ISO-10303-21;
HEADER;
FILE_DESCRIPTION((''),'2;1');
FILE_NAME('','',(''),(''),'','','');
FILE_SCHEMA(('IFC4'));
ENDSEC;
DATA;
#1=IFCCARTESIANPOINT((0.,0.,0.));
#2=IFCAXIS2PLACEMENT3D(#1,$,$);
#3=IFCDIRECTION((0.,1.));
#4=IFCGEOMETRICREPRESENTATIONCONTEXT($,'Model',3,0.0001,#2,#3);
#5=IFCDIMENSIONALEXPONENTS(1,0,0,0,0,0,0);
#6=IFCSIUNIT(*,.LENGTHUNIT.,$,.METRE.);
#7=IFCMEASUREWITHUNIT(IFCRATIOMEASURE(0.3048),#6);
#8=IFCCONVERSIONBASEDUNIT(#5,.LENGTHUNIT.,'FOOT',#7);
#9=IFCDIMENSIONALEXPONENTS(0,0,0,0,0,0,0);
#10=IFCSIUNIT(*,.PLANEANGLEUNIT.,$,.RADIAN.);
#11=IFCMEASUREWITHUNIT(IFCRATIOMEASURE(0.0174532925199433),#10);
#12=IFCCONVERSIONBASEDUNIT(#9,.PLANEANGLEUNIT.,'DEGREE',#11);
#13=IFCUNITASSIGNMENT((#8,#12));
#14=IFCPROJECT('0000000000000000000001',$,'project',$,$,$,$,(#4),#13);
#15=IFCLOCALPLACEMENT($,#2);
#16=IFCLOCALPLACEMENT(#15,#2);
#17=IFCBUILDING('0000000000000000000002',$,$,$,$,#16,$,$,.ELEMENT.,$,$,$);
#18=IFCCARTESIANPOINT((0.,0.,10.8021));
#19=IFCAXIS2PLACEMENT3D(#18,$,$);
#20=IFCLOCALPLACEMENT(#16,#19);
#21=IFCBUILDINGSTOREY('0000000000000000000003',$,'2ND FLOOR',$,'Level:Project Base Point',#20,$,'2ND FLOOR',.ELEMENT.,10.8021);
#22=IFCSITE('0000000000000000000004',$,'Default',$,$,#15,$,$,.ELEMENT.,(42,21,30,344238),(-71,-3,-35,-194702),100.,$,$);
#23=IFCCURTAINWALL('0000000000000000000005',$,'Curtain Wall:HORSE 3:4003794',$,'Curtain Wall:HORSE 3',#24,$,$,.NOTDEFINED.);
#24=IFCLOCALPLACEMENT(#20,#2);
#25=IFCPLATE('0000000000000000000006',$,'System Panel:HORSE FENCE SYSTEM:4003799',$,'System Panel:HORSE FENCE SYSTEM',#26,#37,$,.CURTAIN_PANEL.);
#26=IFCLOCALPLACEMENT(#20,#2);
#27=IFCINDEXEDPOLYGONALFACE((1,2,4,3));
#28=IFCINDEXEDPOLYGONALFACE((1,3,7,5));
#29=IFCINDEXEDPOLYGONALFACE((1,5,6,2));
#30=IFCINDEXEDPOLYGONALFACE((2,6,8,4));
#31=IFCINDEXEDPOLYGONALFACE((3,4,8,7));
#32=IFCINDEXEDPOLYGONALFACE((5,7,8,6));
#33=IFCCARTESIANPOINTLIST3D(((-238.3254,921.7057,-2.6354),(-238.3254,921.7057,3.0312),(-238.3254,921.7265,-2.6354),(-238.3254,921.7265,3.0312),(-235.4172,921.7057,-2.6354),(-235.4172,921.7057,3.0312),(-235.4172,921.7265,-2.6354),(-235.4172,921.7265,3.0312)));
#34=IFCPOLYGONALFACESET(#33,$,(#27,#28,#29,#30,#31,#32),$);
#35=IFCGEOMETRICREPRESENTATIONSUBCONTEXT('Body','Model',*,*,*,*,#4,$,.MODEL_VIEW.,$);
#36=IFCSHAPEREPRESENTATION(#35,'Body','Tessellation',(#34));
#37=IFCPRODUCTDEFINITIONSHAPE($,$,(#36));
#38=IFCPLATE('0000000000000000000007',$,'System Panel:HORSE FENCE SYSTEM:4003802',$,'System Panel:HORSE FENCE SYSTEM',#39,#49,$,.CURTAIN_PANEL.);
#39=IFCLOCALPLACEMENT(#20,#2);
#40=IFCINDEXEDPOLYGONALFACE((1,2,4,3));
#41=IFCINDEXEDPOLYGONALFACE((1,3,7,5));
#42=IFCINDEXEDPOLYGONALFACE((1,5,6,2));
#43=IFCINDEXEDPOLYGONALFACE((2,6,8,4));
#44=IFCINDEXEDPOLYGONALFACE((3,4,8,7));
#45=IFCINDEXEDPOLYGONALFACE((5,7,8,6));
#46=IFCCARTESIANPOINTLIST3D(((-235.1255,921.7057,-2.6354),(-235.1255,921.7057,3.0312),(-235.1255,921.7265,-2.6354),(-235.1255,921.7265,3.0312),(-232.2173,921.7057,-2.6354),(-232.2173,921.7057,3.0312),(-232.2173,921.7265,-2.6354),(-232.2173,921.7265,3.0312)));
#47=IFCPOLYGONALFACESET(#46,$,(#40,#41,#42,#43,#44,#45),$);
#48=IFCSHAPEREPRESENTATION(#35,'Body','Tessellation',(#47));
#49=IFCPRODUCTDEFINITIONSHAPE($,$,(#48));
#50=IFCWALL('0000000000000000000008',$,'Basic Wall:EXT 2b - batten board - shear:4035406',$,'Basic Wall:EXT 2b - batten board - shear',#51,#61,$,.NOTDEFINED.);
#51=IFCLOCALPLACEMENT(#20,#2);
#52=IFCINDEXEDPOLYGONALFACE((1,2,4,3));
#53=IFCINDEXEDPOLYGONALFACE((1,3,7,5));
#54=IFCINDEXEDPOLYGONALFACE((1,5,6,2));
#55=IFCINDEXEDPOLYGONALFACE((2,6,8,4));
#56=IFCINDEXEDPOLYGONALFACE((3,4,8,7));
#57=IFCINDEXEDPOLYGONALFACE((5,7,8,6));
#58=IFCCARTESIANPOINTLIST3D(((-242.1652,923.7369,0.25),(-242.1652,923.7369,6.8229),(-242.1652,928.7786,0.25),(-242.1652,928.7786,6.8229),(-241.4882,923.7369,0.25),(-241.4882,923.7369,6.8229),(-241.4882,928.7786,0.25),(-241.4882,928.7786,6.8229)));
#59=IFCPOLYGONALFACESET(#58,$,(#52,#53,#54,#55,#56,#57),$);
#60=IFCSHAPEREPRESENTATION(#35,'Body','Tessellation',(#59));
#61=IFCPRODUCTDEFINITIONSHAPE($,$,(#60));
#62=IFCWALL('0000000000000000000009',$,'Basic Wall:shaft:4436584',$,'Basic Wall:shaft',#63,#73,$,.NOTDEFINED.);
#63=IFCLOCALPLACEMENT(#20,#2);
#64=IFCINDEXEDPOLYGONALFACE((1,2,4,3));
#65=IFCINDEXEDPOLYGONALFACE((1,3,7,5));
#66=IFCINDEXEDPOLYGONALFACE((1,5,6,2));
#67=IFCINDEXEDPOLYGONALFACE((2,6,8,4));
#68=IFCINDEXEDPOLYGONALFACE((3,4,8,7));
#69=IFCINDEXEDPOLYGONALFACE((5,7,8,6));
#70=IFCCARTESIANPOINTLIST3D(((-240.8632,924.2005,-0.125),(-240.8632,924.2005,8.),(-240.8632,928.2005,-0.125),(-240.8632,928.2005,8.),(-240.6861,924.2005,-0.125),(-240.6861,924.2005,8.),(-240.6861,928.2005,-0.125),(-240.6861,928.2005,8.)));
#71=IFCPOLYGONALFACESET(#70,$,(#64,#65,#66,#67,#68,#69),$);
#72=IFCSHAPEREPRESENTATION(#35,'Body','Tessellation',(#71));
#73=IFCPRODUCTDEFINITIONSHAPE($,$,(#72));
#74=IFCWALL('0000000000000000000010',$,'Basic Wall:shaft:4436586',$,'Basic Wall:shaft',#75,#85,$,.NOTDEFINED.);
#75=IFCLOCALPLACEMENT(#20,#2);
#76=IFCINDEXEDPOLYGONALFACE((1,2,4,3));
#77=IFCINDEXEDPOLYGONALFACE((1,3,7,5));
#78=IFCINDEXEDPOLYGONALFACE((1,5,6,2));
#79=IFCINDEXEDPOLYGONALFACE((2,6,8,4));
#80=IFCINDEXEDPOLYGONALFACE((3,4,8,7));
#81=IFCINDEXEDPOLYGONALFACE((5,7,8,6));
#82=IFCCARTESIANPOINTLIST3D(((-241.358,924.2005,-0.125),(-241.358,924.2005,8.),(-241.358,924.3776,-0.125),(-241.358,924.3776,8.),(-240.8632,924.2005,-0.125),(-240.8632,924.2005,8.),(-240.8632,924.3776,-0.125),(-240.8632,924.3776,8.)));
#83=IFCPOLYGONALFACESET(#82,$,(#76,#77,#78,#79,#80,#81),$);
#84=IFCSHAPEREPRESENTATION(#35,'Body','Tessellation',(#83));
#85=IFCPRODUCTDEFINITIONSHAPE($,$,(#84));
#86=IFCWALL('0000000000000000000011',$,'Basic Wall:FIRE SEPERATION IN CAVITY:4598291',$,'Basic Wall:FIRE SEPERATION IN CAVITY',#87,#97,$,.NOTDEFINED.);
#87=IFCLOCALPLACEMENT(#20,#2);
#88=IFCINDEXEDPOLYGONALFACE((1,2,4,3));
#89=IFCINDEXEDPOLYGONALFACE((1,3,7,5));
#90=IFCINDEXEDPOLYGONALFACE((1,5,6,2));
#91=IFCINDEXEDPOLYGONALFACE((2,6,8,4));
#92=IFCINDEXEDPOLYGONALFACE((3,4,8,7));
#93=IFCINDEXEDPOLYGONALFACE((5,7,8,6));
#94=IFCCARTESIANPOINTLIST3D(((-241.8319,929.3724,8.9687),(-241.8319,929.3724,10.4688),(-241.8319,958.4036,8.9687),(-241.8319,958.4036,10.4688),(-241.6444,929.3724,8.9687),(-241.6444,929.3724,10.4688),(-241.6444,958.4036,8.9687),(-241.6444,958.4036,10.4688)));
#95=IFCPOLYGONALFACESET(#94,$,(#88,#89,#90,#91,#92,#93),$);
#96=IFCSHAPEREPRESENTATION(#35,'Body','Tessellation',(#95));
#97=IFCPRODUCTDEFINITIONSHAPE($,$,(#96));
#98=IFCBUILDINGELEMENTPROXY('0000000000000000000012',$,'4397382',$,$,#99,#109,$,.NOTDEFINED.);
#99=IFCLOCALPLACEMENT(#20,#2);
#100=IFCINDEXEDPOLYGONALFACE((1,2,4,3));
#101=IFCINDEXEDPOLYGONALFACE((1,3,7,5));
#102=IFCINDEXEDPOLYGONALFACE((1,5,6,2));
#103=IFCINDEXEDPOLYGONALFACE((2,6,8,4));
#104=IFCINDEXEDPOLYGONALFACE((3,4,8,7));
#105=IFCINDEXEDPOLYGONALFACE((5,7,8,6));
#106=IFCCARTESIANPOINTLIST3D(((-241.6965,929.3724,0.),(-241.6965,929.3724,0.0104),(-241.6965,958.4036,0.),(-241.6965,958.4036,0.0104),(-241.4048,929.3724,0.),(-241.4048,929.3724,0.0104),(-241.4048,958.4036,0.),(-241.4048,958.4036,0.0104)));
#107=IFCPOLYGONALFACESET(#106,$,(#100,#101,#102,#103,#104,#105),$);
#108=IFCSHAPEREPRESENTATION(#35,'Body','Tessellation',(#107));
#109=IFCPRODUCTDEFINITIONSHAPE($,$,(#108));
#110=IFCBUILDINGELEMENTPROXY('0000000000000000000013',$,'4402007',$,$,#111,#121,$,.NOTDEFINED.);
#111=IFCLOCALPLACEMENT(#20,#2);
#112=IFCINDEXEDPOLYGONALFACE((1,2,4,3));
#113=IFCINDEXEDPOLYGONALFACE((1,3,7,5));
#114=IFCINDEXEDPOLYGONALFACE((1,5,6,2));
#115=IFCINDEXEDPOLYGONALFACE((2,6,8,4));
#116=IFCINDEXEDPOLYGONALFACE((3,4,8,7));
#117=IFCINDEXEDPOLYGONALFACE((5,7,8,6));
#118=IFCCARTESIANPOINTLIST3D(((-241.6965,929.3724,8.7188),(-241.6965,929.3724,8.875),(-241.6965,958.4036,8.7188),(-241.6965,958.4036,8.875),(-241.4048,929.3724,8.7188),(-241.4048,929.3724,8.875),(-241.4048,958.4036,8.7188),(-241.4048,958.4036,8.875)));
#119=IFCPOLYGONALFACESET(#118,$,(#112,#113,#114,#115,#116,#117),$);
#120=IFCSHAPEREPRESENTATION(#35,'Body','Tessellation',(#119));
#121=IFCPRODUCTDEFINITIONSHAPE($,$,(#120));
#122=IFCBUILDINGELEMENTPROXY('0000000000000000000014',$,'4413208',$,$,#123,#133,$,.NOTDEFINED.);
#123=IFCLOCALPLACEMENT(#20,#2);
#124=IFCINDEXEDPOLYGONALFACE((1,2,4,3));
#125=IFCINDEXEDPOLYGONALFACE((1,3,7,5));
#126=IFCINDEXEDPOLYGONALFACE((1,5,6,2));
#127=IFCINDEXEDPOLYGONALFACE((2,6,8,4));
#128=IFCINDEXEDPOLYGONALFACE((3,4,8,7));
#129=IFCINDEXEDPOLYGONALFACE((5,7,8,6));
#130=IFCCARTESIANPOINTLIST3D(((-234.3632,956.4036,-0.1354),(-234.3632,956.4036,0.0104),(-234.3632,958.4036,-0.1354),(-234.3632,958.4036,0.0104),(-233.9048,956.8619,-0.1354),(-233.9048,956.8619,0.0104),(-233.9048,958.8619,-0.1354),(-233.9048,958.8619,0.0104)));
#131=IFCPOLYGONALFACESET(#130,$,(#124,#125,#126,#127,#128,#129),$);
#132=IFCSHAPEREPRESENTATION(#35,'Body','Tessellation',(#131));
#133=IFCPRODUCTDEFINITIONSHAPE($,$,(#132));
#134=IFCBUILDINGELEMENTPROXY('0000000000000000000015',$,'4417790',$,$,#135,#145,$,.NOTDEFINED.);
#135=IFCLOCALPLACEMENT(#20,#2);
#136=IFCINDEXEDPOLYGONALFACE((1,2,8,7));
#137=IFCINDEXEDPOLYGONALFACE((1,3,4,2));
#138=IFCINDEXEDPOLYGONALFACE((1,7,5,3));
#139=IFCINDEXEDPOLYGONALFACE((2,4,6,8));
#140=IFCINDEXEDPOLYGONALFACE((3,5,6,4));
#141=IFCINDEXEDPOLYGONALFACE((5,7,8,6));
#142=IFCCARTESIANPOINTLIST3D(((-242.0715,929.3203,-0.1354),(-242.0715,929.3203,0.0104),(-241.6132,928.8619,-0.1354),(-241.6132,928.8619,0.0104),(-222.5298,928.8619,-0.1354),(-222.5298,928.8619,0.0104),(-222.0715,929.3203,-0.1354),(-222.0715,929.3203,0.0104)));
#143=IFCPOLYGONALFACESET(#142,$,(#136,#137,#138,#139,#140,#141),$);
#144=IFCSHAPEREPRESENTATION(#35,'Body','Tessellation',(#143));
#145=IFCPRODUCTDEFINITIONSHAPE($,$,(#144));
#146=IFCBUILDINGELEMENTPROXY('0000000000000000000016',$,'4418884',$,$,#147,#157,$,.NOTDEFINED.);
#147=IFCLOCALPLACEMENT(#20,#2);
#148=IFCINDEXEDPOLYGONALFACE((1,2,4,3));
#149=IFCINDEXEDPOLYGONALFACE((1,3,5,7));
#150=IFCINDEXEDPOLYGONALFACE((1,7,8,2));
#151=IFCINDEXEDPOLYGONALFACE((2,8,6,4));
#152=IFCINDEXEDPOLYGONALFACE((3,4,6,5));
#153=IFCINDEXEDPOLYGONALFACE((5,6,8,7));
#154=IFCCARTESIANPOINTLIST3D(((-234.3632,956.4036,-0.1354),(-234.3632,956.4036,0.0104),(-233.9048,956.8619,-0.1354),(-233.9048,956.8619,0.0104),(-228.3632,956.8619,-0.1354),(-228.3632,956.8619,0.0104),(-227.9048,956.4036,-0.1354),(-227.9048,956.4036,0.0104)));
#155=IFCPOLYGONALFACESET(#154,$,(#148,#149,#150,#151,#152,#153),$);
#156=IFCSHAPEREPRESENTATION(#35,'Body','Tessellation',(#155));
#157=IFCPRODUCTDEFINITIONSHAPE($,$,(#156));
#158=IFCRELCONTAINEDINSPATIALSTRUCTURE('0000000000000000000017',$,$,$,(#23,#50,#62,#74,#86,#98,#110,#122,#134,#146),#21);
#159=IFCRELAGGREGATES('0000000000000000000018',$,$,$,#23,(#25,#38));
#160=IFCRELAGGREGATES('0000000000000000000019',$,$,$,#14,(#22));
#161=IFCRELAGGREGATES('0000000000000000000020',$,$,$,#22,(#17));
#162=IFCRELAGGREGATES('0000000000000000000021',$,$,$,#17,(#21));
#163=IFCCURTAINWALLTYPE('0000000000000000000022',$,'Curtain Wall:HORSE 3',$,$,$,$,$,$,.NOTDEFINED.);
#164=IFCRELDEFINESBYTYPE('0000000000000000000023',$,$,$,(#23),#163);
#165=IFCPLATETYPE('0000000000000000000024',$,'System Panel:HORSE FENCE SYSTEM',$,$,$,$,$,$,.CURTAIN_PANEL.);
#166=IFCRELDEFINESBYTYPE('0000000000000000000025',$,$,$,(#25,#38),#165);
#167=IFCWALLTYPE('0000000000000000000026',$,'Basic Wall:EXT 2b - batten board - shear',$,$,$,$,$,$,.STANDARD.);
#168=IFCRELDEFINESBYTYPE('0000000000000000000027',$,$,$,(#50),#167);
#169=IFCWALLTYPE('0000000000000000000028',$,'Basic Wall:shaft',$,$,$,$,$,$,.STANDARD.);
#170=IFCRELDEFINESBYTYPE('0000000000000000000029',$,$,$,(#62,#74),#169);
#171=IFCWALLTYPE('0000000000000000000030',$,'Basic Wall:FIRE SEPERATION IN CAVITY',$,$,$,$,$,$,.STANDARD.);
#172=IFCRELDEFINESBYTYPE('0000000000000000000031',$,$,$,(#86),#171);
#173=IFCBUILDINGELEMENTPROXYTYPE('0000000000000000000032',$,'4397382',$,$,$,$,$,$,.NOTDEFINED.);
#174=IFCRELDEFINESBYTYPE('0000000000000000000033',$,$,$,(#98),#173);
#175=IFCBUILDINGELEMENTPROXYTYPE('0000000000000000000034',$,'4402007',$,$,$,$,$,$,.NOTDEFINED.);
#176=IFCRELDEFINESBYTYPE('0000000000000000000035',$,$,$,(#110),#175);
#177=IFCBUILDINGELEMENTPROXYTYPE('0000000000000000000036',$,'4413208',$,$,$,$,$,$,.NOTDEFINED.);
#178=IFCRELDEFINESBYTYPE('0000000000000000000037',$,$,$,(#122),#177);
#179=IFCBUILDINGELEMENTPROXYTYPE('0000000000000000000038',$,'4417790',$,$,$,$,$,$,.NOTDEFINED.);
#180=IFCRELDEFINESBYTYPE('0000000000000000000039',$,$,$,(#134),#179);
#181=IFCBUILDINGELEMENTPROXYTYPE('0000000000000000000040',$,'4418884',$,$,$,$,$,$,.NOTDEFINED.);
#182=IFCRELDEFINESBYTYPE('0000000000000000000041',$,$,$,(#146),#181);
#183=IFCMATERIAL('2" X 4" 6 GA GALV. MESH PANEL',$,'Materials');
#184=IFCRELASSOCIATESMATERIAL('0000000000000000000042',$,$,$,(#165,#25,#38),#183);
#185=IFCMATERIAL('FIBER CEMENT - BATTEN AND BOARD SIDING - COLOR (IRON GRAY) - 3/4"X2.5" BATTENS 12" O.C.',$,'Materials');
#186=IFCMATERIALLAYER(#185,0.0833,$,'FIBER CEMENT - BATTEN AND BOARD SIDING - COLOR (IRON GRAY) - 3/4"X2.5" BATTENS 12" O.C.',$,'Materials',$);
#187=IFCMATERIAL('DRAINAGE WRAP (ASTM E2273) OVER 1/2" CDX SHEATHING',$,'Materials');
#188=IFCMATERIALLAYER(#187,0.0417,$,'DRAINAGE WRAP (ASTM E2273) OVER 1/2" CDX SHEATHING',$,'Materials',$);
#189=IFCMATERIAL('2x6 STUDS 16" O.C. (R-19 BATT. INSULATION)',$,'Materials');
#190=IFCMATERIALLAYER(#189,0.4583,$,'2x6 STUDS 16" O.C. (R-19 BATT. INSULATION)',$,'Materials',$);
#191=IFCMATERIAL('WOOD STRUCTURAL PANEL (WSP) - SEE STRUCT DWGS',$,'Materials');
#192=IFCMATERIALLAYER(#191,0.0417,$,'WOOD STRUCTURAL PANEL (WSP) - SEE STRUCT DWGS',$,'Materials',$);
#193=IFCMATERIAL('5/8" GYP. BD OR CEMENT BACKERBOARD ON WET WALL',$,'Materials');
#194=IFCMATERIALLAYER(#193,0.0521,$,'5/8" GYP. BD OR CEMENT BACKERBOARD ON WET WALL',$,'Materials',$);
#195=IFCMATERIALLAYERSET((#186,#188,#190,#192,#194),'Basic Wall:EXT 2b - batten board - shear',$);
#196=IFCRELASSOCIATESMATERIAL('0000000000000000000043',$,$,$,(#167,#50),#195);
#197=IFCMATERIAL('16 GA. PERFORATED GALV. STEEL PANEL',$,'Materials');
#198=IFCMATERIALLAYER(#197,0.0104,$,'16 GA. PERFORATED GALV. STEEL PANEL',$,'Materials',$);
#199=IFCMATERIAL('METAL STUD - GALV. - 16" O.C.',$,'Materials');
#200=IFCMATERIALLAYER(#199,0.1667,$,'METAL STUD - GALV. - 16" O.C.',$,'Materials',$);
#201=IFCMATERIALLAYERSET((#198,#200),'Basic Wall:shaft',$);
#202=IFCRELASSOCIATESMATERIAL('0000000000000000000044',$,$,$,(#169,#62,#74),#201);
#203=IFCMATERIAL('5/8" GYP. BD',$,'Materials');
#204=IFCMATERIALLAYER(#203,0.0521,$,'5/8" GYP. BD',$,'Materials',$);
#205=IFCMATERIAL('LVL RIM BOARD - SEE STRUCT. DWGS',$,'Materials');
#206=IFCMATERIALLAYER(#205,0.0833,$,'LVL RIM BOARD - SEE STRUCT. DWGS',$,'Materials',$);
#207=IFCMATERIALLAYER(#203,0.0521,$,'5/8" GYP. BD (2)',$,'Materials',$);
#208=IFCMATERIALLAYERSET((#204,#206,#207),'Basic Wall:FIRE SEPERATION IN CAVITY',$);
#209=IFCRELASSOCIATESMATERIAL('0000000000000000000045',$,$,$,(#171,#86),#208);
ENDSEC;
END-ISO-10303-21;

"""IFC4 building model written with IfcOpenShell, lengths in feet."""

from ifc_helpers import new_model, entity, si_unit, converted_unit, direction, frame, frame_2d, origin, place, context, subcontext, project, spatial, polyline, rectangle, outline, extrude, source, transform, mapped, material, layer, layer_set, layer_usage, type_object, type_shapes, element, aggregate, save


model = new_model("IFC4")

# Units and contexts
model_context = context("Model", 3, precision=0.0001, world=origin(), true_north=direction((0.0, 1.0)))
body_context = subcontext(model_context, "Body", "Model", "MODEL_VIEW")
ifc_project = project(units=[converted_unit("LENGTHUNIT", "FOOT", entity("IfcRatioMeasure", 0.3048), si_unit("LENGTHUNIT", "METRE"), dimensions=[1, 0, 0, 0, 0, 0, 0]), converted_unit("PLANEANGLEUNIT", "DEGREE", entity("IfcRatioMeasure", 0.0174532925199433), si_unit("PLANEANGLEUNIT", "RADIAN"), dimensions=[0, 0, 0, 0, 0, 0, 0])], contexts=[model_context])

# Site, building, storey
site_placement = place(None, origin())
site = spatial("IfcSite", under=ifc_project, at=site_placement, Name="Default", CompositionType="ELEMENT", RefLatitude=(42, 21, 30, 344238), RefLongitude=(-71, -3, -35, -194702), RefElevation=100.0)
building_placement = place(site_placement, origin())
building = spatial("IfcBuilding", under=site, at=building_placement, CompositionType="ELEMENT")
storey_placement = place(building_placement, frame((0.0, 0.0, 10.8021)))
storey = spatial("IfcBuildingStorey", under=building, at=storey_placement, Name="2ND FLOOR", ObjectType="Level:Project Base Point", LongName="2ND FLOOR", CompositionType="ELEMENT", Elevation=10.8021)

# Curtain wall
curtain_wall_type = type_object("IfcCurtainWallType", Name="Curtain Wall:HORSE 3", PredefinedType="NOTDEFINED")
curtain_wall_1_placement = place(storey_placement, frame((0.0, 0.0, -10.8021)))
curtain_wall_1 = element("IfcCurtainWall", 1, at=curtain_wall_1_placement, inside=storey, type_object=curtain_wall_type, Name="Curtain Wall:HORSE 3:4003794", ObjectType="Curtain Wall:HORSE 3", PredefinedType="NOTDEFINED")

# Plates
ifc_material_1 = material(Name="2\" X 4\" 6 GA GALV. MESH PANEL", Category="Materials")
plate_type_1 = type_object("IfcPlateType", Name="System Panel:HORSE FENCE SYSTEM", PredefinedType="CURTAIN_PANEL", material=ifc_material_1)
shared_shape_1 = source(origin(), body_context, "Body", "SweptSolid", [
    extrude(rectangle(XDim=0.0208, YDim=2.9082, at=frame_2d((0.0, 0.0), x_axis=(1.0, 0.0))), frame((1.4541, 0.0104, 0.0), z_axis=(0.0, 0.0, 1.0), x_axis=(0.0, 1.0, 0.0)), (0.0, 0.0, 1.0), 5.6667),
])
type_shapes(plate_type_1, [shared_shape_1])
plate_1_placement = place(curtain_wall_1_placement, frame((-238.3254, 921.7057, 8.1667)))
plate_1 = element("IfcPlate", 2, at=plate_1_placement, type_object=plate_type_1, material=ifc_material_1, Name="System Panel:HORSE FENCE SYSTEM:4003799", ObjectType="System Panel:HORSE FENCE SYSTEM", PredefinedType="CURTAIN_PANEL", context=body_context, shape_type="MappedRepresentation", body=[
    mapped(shared_shape_1, transform((0.0, 0.0, 0.0), scale=1.0)),
])
plate_2_placement = place(curtain_wall_1_placement, frame((-235.1255, 921.7057, 8.1667)))
plate_2 = element("IfcPlate", 3, at=plate_2_placement, type_object=plate_type_1, material=ifc_material_1, Name="System Panel:HORSE FENCE SYSTEM:4003802", ObjectType="System Panel:HORSE FENCE SYSTEM", PredefinedType="CURTAIN_PANEL", context=body_context, shape_type="MappedRepresentation", body=[
    mapped(shared_shape_1, transform((0.0, 0.0, 0.0), scale=1.0)),
])
aggregate(curtain_wall_1, [plate_1, plate_2])

# Walls
ifc_material_2 = material(Name="FIBER CEMENT - BATTEN AND BOARD SIDING - COLOR (IRON GRAY) - 3/4\"X2.5\" BATTENS 12\" O.C.", Category="Materials")
ifc_layer_1 = layer(ifc_material_2, 0.0833, Name="FIBER CEMENT - BATTEN AND BOARD SIDING - COLOR (IRON GRAY) - 3/4\"X2.5\" BATTENS 12\" O.C.", Category="Materials")
ifc_material_3 = material(Name="DRAINAGE WRAP (ASTM E2273) OVER 1/2\" CDX SHEATHING", Category="Materials")
ifc_layer_2 = layer(ifc_material_3, 0.0417, Name="DRAINAGE WRAP (ASTM E2273) OVER 1/2\" CDX SHEATHING", Category="Materials")
ifc_material_4 = material(Name="2x6 STUDS 16\" O.C. (R-19 BATT. INSULATION)", Category="Materials")
ifc_layer_3 = layer(ifc_material_4, 0.4583, Name="2x6 STUDS 16\" O.C. (R-19 BATT. INSULATION)", Category="Materials")
ifc_material_5 = material(Name="WOOD STRUCTURAL PANEL (WSP) - SEE STRUCT DWGS", Category="Materials")
ifc_layer_4 = layer(ifc_material_5, 0.0417, Name="WOOD STRUCTURAL PANEL (WSP) - SEE STRUCT DWGS", Category="Materials")
ifc_material_6 = material(Name="5/8\" GYP. BD OR CEMENT BACKERBOARD ON WET WALL", Category="Materials")
ifc_layer_5 = layer(ifc_material_6, 0.0521, Name="5/8\" GYP. BD OR CEMENT BACKERBOARD ON WET WALL", Category="Materials")
ifc_layer_set_1 = layer_set([ifc_layer_1, ifc_layer_2, ifc_layer_3, ifc_layer_4, ifc_layer_5], Name="Basic Wall:EXT 2b - batten board - shear")
ifc_layer_usage_1 = layer_usage(ifc_layer_set_1, "AXIS2", "NEGATIVE", 0.3385)
wall_type_1 = type_object("IfcWallType", Name="Basic Wall:EXT 2b - batten board - shear", PredefinedType="STANDARD", material=ifc_layer_set_1)
wall_1_placement = place(storey_placement, frame((-241.8267, 928.7786, 0.25), z_axis=(0.0, 0.0, 1.0), x_axis=(0.0, -1.0, 0.0)))
element("IfcWall", 4, at=wall_1_placement, inside=storey, type_object=wall_type_1, material=ifc_layer_usage_1, Name="Basic Wall:EXT 2b - batten board - shear:4035406", ObjectType="Basic Wall:EXT 2b - batten board - shear", PredefinedType="NOTDEFINED", context=body_context, shape_type="SweptSolid", body=[
    extrude(rectangle(XDim=5.0417, YDim=0.6771, at=frame_2d((2.5208, 0.0), x_axis=(-1.0, 0.0))), origin(), (0.0, 0.0, 1.0), 6.5729),
])
ifc_material_7 = material(Name="16 GA. PERFORATED GALV. STEEL PANEL", Category="Materials")
ifc_layer_6 = layer(ifc_material_7, 0.0104, Name="16 GA. PERFORATED GALV. STEEL PANEL", Category="Materials")
ifc_material_8 = material(Name="METAL STUD - GALV. - 16\" O.C.", Category="Materials")
ifc_layer_7 = layer(ifc_material_8, 0.1667, Name="METAL STUD - GALV. - 16\" O.C.", Category="Materials")
ifc_layer_set_2 = layer_set([ifc_layer_6, ifc_layer_7], Name="Basic Wall:shaft")
ifc_layer_usage_2 = layer_usage(ifc_layer_set_2, "AXIS2", "NEGATIVE", 0.0885)
wall_type_2 = type_object("IfcWallType", Name="Basic Wall:shaft", PredefinedType="STANDARD", material=ifc_layer_set_2)
wall_2_placement = place(storey_placement, frame((-240.7746, 928.2005, -0.125), z_axis=(0.0, 0.0, 1.0), x_axis=(0.0, -1.0, 0.0)))
element("IfcWall", 5, at=wall_2_placement, inside=storey, type_object=wall_type_2, material=ifc_layer_usage_2, Name="Basic Wall:shaft:4436584", ObjectType="Basic Wall:shaft", PredefinedType="NOTDEFINED", context=body_context, shape_type="SweptSolid", body=[
    extrude(rectangle(XDim=4.0, YDim=0.1771, at=frame_2d((2.0, 0.0), x_axis=(-1.0, 0.0))), origin(), (0.0, 0.0, 1.0), 8.125),
])
ifc_layer_usage_3 = layer_usage(ifc_layer_set_2, "AXIS2", "POSITIVE", -0.0885)
wall_3_placement = place(storey_placement, frame((-241.358, 924.289, -0.125)))
element("IfcWall", 6, at=wall_3_placement, inside=storey, type_object=wall_type_2, material=ifc_layer_usage_3, Name="Basic Wall:shaft:4436586", ObjectType="Basic Wall:shaft", PredefinedType="NOTDEFINED", context=body_context, shape_type="SweptSolid", body=[
    extrude(rectangle(XDim=0.4948, YDim=0.1771, at=frame_2d((0.2474, 0.0), x_axis=(-1.0, 0.0))), origin(), (0.0, 0.0, 1.0), 8.125),
])
ifc_material_9 = material(Name="5/8\" GYP. BD", Category="Materials")
ifc_layer_8 = layer(ifc_material_9, 0.0521, Name="5/8\" GYP. BD", Category="Materials")
ifc_material_10 = material(Name="LVL RIM BOARD - SEE STRUCT. DWGS", Category="Materials")
ifc_layer_9 = layer(ifc_material_10, 0.0833, Name="LVL RIM BOARD - SEE STRUCT. DWGS", Category="Materials")
ifc_layer_10 = layer(ifc_material_9, 0.0521, Name="5/8\" GYP. BD (2)", Category="Materials")
ifc_layer_set_3 = layer_set([ifc_layer_8, ifc_layer_9, ifc_layer_10], Name="Basic Wall:FIRE SEPERATION IN CAVITY")
ifc_layer_usage_4 = layer_usage(ifc_layer_set_3, "AXIS2", "NEGATIVE", 0.0938)
wall_type_3 = type_object("IfcWallType", Name="Basic Wall:FIRE SEPERATION IN CAVITY", PredefinedType="STANDARD", material=ifc_layer_set_3)
wall_4_placement = place(storey_placement, frame((-241.7382, 929.3724, 8.9687), z_axis=(0.0, 0.0, 1.0), x_axis=(0.0, 1.0, 0.0)))
element("IfcWall", 7, at=wall_4_placement, inside=storey, type_object=wall_type_3, material=ifc_layer_usage_4, Name="Basic Wall:FIRE SEPERATION IN CAVITY:4598291", ObjectType="Basic Wall:FIRE SEPERATION IN CAVITY", PredefinedType="NOTDEFINED", context=body_context, shape_type="SweptSolid", body=[
    extrude(rectangle(XDim=29.0313, YDim=0.1875, at=frame_2d((14.5156, 0.0), x_axis=(-1.0, 0.0))), origin(), (0.0, 0.0, 1.0), 1.5),
])

# Building element proxies
building_element_proxy_type_1 = type_object("IfcBuildingElementProxyType", Name="4397382", PredefinedType="NOTDEFINED")
proxy_1_placement = place(storey_placement, frame((-241.6965, 929.3724, 0.0)))
element("IfcBuildingElementProxy", 8, at=proxy_1_placement, inside=storey, type_object=building_element_proxy_type_1, Name="4397382", PredefinedType="NOTDEFINED", context=body_context, shape_type="SweptSolid", body=[
    extrude(rectangle(XDim=29.0313, YDim=0.2917, at=frame_2d((0.0, 0.0), x_axis=(1.0, 0.0))), frame((0.1458, 14.5156, 0.0), z_axis=(0.0, 0.0, 1.0), x_axis=(0.0, 1.0, 0.0)), (0.0, 0.0, 1.0), 0.0104),
])
building_element_proxy_type_2 = type_object("IfcBuildingElementProxyType", Name="4402007", PredefinedType="NOTDEFINED")
proxy_2_placement = place(storey_placement, frame((-241.6965, 929.3724, 8.7188)))
element("IfcBuildingElementProxy", 9, at=proxy_2_placement, inside=storey, type_object=building_element_proxy_type_2, Name="4402007", PredefinedType="NOTDEFINED", context=body_context, shape_type="SweptSolid", body=[
    extrude(rectangle(XDim=29.0313, YDim=0.2917, at=frame_2d((0.0, 0.0), x_axis=(1.0, 0.0))), frame((0.1458, 14.5156, 0.0), z_axis=(0.0, 0.0, 1.0), x_axis=(0.0, 1.0, 0.0)), (0.0, 0.0, 1.0), 0.1562),
])
building_element_proxy_type_3 = type_object("IfcBuildingElementProxyType", Name="4413208", PredefinedType="NOTDEFINED")
proxy_3_placement = place(storey_placement, frame((-234.3632, 956.4036, -0.1354)))
element("IfcBuildingElementProxy", 10, at=proxy_3_placement, inside=storey, type_object=building_element_proxy_type_3, Name="4413208", PredefinedType="NOTDEFINED", context=body_context, shape_type="SweptSolid", body=[
    extrude(outline(polyline([(-0.7708, -0.2292), (1.2292, -0.2292), (0.7708, 0.2292), (-1.2292, 0.2292), (-0.7708, -0.2292)])), frame((0.2292, 1.2292, 0.0), z_axis=(0.0, 0.0, 1.0), x_axis=(0.0, -1.0, 0.0)), (0.0, 0.0, 1.0), 0.1458),
])
building_element_proxy_type_4 = type_object("IfcBuildingElementProxyType", Name="4417790", PredefinedType="NOTDEFINED")
proxy_4_placement = place(storey_placement, frame((-242.0715, 928.8619, -0.1354)))
element("IfcBuildingElementProxy", 11, at=proxy_4_placement, inside=storey, type_object=building_element_proxy_type_4, Name="4417790", PredefinedType="NOTDEFINED", context=body_context, shape_type="SweptSolid", body=[
    extrude(outline(polyline([(-9.5417, -0.2292), (9.5417, -0.2292), (10.0, 0.2292), (-10.0, 0.2292), (-9.5417, -0.2292)])), frame((10.0, 0.2292, 0.0)), (0.0, 0.0, 1.0), 0.1458),
])
building_element_proxy_type_5 = type_object("IfcBuildingElementProxyType", Name="4418884", PredefinedType="NOTDEFINED")
proxy_5_placement = place(storey_placement, frame((-234.3632, 956.4036, -0.1354)))
element("IfcBuildingElementProxy", 12, at=proxy_5_placement, inside=storey, type_object=building_element_proxy_type_5, Name="4418884", PredefinedType="NOTDEFINED", context=body_context, shape_type="SweptSolid", body=[
    extrude(outline(polyline([(-3.2292, -0.2292), (3.2292, -0.2292), (2.7708, 0.2292), (-2.7708, 0.2292), (-3.2292, -0.2292)])), frame((3.2292, 0.2292, 0.0)), (0.0, 0.0, 1.0), 0.1458),
])

save(model, "model.ifc")
